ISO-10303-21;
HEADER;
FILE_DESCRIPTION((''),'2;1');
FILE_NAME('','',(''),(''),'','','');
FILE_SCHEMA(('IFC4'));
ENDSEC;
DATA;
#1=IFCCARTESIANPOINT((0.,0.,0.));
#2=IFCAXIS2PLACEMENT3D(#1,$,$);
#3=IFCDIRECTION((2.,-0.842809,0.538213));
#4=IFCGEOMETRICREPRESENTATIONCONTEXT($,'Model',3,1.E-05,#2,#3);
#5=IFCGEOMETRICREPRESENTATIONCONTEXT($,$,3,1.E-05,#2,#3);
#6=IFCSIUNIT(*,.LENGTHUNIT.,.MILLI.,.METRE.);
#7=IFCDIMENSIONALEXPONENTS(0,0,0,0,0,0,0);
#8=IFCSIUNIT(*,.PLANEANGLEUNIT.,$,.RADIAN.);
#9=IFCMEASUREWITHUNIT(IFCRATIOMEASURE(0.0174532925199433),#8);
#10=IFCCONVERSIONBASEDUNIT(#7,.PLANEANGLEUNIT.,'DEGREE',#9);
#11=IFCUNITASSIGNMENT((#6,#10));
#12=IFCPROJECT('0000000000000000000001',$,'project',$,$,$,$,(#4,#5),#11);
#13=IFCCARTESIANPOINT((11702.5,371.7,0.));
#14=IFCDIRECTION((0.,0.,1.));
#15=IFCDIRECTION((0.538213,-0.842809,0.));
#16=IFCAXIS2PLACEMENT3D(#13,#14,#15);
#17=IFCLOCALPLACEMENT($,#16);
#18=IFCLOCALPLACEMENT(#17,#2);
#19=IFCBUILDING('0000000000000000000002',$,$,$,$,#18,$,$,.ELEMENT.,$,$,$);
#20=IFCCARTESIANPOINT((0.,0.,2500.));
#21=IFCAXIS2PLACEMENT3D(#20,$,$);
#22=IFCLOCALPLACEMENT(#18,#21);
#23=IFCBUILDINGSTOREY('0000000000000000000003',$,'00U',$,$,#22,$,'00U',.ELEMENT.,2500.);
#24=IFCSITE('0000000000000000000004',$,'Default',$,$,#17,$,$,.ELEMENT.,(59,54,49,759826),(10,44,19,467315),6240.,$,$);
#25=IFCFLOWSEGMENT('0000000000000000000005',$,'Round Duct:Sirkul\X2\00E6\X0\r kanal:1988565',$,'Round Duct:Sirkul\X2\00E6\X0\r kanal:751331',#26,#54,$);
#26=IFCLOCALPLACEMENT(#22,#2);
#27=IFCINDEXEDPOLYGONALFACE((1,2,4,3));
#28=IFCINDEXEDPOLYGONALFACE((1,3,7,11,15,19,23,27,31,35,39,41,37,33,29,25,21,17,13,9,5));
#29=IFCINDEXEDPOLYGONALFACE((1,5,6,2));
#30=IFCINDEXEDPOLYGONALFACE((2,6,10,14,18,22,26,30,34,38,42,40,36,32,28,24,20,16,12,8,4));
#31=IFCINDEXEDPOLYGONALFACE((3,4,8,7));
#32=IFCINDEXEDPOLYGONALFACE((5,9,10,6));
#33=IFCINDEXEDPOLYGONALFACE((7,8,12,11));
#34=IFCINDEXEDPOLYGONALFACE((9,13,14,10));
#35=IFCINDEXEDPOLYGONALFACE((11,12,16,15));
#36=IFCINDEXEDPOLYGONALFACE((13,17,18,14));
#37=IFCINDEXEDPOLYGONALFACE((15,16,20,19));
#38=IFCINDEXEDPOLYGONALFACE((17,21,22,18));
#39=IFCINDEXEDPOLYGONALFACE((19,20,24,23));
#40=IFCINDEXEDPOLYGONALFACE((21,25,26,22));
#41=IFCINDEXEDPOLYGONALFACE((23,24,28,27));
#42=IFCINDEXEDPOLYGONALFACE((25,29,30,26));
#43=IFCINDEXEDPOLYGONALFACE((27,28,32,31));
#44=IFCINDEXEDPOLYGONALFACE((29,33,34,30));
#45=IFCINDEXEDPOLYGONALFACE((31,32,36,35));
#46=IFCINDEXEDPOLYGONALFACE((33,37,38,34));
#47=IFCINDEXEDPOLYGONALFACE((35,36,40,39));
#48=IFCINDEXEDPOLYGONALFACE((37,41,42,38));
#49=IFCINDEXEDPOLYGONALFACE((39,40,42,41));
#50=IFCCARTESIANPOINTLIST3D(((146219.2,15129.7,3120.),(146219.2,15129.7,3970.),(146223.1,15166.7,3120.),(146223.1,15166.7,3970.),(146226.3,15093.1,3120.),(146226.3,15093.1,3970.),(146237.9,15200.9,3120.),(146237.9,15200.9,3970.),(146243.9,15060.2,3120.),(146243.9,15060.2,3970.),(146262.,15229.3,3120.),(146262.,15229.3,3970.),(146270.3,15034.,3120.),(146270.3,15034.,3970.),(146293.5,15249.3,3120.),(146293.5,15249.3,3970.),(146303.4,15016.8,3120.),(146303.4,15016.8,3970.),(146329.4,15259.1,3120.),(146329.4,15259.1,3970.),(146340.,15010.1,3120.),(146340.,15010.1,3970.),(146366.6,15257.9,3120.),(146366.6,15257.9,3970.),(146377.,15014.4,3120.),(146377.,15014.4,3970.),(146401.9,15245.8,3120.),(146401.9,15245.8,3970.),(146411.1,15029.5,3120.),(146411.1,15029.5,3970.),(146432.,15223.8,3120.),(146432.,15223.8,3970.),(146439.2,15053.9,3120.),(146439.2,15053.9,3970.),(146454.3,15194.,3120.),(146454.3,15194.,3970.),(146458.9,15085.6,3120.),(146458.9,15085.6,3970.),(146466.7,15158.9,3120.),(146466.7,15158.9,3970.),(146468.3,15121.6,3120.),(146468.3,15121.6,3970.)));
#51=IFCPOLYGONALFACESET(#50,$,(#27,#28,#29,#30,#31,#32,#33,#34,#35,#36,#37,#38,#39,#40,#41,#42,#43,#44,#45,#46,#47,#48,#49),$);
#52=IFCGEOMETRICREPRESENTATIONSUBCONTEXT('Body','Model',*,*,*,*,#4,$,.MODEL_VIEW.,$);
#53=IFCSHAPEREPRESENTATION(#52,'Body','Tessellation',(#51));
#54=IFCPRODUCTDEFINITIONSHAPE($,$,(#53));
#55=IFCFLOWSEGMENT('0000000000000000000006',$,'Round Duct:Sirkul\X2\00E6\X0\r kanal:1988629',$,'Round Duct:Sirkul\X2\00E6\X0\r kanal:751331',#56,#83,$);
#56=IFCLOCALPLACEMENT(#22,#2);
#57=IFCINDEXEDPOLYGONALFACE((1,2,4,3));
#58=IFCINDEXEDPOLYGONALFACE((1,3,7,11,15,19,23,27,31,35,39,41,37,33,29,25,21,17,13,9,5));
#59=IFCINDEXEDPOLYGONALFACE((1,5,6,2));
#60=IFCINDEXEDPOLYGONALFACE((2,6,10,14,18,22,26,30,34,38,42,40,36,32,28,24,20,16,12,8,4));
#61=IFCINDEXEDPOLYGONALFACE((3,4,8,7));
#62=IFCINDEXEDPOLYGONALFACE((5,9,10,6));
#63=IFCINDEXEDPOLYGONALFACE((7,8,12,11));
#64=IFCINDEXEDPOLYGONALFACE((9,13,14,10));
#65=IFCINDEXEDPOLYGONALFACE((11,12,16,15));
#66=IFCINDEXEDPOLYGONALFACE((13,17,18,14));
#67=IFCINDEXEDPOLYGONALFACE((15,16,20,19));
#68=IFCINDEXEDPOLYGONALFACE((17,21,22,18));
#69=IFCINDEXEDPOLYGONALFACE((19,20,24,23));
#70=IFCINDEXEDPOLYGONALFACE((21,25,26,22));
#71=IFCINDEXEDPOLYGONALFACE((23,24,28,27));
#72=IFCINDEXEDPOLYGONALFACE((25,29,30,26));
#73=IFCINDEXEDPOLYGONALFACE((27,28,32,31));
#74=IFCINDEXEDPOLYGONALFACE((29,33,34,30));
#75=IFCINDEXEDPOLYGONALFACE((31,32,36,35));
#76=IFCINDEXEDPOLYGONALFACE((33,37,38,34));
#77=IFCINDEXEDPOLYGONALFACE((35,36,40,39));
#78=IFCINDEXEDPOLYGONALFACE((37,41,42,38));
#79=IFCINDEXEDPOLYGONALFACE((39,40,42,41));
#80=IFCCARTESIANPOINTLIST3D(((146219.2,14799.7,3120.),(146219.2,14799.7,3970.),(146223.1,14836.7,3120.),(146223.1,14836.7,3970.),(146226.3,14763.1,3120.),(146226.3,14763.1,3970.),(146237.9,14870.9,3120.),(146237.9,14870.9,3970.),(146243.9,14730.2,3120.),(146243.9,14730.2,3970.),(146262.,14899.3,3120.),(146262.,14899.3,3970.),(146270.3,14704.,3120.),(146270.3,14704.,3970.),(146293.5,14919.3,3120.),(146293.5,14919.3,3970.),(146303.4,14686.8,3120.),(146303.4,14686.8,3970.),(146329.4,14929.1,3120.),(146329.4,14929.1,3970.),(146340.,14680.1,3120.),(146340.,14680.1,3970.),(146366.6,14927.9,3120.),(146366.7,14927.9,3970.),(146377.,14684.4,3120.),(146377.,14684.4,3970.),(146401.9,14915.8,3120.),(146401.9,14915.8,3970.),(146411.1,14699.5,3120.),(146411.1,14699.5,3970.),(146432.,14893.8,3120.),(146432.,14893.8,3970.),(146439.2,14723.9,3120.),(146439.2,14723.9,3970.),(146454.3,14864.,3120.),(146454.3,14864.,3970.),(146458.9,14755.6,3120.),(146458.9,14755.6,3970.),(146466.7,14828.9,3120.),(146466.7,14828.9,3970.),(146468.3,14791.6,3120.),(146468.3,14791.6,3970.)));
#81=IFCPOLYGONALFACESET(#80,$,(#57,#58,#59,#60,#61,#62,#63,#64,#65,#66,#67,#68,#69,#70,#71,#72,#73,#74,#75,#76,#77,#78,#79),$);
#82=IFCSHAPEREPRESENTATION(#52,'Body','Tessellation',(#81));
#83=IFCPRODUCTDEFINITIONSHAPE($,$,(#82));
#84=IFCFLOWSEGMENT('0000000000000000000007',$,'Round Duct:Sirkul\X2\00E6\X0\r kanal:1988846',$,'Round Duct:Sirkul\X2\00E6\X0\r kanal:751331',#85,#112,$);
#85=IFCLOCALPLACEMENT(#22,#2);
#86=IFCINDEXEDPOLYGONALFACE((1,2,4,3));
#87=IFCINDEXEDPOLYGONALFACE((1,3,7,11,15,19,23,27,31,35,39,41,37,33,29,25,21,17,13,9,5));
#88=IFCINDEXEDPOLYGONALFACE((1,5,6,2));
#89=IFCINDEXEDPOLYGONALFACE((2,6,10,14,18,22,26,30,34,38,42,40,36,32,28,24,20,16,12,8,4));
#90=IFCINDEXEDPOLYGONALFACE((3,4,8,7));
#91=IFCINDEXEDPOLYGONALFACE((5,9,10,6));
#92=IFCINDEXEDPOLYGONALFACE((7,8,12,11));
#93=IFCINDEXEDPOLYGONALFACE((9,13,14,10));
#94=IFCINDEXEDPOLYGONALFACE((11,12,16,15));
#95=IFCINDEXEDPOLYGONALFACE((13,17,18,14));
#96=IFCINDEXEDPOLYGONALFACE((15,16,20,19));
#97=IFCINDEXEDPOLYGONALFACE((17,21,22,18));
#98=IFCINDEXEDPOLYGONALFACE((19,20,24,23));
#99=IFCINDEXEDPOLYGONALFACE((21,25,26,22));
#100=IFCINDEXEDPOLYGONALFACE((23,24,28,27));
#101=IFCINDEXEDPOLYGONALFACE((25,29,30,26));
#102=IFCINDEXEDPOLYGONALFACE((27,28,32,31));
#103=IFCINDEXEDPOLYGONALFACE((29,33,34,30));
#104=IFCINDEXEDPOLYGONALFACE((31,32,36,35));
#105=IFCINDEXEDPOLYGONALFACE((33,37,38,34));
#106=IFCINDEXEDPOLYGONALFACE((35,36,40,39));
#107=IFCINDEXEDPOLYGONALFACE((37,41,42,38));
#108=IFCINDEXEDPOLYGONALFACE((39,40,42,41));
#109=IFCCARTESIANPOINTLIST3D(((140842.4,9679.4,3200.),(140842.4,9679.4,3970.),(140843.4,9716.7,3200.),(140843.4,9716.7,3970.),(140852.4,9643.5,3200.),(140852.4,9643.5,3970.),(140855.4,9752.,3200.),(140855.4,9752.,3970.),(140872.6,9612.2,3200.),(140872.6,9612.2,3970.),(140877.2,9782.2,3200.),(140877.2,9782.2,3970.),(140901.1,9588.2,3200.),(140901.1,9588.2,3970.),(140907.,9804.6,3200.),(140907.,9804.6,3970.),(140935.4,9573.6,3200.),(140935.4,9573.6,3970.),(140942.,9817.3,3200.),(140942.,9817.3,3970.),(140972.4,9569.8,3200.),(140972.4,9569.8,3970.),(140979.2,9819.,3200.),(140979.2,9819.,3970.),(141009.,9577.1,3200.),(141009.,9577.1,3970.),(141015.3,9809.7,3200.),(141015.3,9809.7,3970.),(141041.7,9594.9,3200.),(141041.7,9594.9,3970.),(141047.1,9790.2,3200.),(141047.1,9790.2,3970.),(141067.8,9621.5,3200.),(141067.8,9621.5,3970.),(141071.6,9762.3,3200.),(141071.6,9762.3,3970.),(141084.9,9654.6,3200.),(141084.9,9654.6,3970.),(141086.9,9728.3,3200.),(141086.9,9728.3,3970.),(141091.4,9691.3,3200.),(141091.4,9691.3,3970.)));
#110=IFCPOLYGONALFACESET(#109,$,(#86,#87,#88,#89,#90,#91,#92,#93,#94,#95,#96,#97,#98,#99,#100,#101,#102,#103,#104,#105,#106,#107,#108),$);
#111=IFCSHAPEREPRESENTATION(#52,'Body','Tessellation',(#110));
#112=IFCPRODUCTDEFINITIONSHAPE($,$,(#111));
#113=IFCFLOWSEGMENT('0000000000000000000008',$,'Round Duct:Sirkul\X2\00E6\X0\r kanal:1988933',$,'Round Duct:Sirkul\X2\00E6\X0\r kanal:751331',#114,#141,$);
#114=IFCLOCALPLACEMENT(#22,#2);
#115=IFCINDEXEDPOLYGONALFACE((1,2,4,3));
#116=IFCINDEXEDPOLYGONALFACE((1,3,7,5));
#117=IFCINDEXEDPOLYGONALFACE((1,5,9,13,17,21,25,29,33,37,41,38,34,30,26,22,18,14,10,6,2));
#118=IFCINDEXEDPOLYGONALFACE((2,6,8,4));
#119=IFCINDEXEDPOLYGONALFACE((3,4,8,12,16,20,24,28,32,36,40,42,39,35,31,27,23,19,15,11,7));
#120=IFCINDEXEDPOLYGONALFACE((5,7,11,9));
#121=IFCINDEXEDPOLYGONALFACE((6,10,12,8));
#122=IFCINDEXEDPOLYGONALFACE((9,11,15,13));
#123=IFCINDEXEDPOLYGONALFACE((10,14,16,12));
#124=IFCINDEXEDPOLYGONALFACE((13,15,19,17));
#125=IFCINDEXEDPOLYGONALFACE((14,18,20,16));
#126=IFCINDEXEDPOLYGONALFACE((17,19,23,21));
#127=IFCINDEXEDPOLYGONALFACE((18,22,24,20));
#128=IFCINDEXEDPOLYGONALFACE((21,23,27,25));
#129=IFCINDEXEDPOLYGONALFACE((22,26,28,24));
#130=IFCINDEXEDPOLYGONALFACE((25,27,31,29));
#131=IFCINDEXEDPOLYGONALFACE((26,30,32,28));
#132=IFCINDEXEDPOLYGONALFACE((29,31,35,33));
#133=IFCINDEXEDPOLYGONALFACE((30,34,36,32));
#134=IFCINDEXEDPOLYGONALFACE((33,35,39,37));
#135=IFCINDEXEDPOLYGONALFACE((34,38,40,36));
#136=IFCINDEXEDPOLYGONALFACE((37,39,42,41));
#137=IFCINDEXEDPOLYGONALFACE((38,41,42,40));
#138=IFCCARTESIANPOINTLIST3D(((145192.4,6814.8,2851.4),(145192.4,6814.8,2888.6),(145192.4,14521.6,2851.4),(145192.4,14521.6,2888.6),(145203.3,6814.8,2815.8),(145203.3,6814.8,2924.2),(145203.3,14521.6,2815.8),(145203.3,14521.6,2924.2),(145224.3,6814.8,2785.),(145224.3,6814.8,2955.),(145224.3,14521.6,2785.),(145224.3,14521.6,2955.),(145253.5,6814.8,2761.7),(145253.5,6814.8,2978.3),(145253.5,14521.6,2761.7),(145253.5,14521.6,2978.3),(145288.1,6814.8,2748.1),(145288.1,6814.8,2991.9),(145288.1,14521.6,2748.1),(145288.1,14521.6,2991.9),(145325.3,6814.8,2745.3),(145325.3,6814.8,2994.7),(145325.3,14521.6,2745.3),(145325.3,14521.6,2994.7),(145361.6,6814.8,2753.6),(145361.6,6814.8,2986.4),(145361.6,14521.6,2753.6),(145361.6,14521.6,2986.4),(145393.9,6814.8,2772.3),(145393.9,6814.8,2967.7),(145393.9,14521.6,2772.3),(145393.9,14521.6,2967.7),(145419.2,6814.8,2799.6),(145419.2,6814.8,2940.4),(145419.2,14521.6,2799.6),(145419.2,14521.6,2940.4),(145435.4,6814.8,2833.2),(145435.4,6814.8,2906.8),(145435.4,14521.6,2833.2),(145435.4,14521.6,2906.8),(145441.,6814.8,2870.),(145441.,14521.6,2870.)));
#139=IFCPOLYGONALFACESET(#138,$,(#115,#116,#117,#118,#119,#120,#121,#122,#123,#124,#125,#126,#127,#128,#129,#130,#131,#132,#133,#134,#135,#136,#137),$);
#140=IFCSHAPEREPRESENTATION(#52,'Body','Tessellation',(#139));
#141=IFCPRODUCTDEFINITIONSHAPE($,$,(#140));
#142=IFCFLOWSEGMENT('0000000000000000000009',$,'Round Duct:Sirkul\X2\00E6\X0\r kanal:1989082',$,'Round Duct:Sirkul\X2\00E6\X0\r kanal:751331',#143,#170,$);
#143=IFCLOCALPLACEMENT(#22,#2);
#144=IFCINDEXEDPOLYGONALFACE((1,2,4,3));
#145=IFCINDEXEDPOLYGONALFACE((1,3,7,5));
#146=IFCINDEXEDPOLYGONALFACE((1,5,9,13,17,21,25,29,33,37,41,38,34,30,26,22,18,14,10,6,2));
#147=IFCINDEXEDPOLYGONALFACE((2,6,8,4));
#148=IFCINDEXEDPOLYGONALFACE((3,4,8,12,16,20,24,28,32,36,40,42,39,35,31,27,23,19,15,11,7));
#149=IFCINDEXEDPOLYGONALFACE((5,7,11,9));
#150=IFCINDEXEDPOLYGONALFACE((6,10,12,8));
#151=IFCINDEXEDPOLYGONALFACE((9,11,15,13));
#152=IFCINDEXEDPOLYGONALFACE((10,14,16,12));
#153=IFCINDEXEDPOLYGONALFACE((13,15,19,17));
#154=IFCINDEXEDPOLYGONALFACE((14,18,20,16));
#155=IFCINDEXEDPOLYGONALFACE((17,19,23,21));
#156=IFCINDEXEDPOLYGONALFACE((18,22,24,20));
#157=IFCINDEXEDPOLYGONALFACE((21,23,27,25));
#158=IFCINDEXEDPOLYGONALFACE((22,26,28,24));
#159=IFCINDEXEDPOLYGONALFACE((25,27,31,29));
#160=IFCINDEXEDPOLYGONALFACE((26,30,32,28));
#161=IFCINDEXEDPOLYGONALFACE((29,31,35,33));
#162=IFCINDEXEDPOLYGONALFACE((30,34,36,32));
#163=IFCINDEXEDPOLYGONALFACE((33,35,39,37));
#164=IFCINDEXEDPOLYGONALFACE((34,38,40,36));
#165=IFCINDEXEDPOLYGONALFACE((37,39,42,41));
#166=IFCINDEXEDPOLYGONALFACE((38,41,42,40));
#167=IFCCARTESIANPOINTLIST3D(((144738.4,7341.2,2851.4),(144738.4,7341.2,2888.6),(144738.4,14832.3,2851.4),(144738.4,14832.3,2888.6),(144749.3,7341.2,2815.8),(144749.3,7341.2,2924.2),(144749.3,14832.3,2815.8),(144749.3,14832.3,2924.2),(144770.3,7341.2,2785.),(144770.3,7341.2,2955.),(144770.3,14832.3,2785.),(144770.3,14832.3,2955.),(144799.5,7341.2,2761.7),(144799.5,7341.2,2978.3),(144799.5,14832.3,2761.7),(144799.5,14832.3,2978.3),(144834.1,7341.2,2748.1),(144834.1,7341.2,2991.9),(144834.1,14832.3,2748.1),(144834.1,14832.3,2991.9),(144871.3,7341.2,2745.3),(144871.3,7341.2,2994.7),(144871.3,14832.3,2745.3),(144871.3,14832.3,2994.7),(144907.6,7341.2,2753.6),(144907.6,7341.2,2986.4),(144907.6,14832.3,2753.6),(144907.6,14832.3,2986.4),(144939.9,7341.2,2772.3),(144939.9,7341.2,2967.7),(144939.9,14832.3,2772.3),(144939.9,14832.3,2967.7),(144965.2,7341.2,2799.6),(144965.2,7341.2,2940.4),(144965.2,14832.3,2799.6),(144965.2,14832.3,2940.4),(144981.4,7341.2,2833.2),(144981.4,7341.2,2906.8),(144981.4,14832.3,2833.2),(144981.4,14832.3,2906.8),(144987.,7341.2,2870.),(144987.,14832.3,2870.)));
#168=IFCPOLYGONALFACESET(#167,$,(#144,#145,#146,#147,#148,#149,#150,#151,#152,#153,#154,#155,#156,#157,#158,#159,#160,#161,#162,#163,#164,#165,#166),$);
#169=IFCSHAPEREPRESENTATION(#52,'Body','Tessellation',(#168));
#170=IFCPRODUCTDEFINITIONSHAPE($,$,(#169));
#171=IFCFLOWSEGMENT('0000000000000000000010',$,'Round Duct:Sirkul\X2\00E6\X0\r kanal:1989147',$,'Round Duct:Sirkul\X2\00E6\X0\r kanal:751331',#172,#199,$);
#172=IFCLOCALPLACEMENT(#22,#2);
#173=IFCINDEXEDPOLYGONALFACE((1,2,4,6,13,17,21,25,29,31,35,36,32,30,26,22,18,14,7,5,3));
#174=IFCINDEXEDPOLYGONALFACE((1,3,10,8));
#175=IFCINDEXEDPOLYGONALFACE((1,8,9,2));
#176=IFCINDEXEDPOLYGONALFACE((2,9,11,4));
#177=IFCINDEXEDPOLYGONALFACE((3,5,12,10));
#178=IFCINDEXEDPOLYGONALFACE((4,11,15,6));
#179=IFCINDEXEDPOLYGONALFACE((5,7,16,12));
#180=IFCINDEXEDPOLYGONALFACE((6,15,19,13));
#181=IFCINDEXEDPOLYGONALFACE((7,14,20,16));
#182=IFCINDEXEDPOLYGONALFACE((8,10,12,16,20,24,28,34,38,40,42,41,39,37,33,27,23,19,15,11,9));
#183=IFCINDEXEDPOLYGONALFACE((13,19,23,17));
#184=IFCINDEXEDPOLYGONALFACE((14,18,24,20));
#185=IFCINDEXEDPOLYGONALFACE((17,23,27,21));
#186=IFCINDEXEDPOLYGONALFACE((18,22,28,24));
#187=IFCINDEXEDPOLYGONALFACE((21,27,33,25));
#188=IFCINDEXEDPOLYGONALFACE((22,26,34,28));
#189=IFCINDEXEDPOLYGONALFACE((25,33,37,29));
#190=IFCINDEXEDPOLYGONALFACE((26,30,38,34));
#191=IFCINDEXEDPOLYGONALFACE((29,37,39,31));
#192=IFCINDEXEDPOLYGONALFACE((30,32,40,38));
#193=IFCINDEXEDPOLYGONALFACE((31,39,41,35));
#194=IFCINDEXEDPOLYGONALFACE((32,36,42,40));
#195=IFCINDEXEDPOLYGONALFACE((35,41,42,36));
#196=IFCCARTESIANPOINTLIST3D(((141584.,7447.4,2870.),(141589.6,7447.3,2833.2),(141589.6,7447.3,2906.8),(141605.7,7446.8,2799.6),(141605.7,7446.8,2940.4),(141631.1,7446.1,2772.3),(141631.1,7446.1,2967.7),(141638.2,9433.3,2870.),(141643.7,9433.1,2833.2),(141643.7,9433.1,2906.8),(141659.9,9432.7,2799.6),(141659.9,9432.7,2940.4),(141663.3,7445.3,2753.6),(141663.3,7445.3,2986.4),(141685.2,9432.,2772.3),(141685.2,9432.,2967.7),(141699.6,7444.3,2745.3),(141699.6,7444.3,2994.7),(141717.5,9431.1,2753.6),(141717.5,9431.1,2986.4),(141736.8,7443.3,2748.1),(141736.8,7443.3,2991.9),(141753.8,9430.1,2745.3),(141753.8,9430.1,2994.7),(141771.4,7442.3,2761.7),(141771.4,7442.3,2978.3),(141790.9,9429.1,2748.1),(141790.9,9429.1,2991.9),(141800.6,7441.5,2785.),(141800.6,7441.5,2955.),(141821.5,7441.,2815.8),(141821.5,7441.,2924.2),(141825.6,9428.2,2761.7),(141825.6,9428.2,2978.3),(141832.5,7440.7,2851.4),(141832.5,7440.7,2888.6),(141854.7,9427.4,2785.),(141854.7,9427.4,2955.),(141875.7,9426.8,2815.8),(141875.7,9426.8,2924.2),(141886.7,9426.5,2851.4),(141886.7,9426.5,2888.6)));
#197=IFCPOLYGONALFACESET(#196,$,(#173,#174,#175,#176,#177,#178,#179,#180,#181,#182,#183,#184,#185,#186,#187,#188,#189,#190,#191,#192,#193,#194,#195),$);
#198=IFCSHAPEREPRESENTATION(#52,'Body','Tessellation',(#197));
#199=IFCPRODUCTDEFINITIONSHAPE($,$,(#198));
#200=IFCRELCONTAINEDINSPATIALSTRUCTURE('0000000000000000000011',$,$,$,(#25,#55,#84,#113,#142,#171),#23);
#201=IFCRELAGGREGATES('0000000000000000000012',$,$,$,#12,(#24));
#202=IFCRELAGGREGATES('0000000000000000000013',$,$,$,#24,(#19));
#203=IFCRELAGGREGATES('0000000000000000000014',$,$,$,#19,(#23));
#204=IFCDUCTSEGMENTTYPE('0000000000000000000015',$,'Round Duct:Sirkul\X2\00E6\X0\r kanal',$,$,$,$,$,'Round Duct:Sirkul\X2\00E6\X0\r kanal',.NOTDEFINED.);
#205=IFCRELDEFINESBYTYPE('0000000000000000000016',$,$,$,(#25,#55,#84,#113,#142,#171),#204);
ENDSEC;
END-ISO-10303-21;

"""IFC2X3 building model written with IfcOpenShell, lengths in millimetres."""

from ifc_helpers import new_model, entity, si_unit, converted_unit, direction, frame, frame_2d, origin, origin_2d_with_axis, place, context, subcontext, project, spatial, circle, extrude, type_object, element, save


model = new_model("IFC2X3")

# Units and contexts
model_context = context("Model", 3, precision=1e-05, world=origin(), true_north=direction((2.0, -0.842809, 0.538213)))
context_of_model = context(None, 3, precision=1e-05, world=origin(), true_north=direction((2.0, -0.842809, 0.538213)))
body_context = subcontext(model_context, "Body", "Model", "MODEL_VIEW")
ifc_project = project(units=[si_unit("LENGTHUNIT", "METRE", prefix="MILLI"), converted_unit("PLANEANGLEUNIT", "DEGREE", entity("IfcRatioMeasure", 0.0174532925199433), si_unit("PLANEANGLEUNIT", "RADIAN"), dimensions=[0, 0, 0, 0, 0, 0, 0])], contexts=[model_context, context_of_model])

# Site, building, storey
site_placement = place(None, frame((11702.5, 371.7, 0.0), z_axis=(0.0, 0.0, 1.0), x_axis=(0.538213, -0.842809, 0.0)))
site = spatial("IfcSite", under=ifc_project, at=site_placement, Name="Default", CompositionType="ELEMENT", RefLatitude=(59, 54, 49, 759826), RefLongitude=(10, 44, 19, 467315), RefElevation=6240.0)
building_placement = place(site_placement, origin())
building = spatial("IfcBuilding", under=site, at=building_placement, CompositionType="ELEMENT")
storey_placement = place(building_placement, frame((0.0, 0.0, 2500.0)))
storey = spatial("IfcBuildingStorey", under=building, at=storey_placement, Name="00U", LongName="00U", CompositionType="ELEMENT", Elevation=2500.0)

# Flow segments
duct_segment_type_1 = type_object("IfcDuctSegmentType", Name="Round Duct:Sirkulær kanal", ElementType="Round Duct:Sirkulær kanal", PredefinedType="NOTDEFINED")
flow_segment_1_placement = place(storey_placement, origin())
element("IfcFlowSegment", 1, at=flow_segment_1_placement, inside=storey, type_object=duct_segment_type_1, Name="Round Duct:Sirkulær kanal:1988565", ObjectType="Round Duct:Sirkulær kanal:751331", context=body_context, shape_type="SweptSolid", body=[
    extrude(circle(Radius=125.0, at=frame_2d((0.0, 0.0), x_axis=(1.0, 0.0))), frame((146344.0, 15135.0, 3120.0), z_axis=(0.000001, 0.0, 1.0), x_axis=(-0.999095, -0.042537, 0.000001)), (0.0, 0.0, 1.0), 850.0),
])
flow_segment_2_placement = place(storey_placement, origin())
element("IfcFlowSegment", 2, at=flow_segment_2_placement, inside=storey, type_object=duct_segment_type_1, Name="Round Duct:Sirkulær kanal:1988629", ObjectType="Round Duct:Sirkulær kanal:751331", context=body_context, shape_type="SweptSolid", body=[
    extrude(circle(Radius=125.0, at=frame_2d((0.0, 0.0), x_axis=(1.0, 0.0))), frame((146344.0, 14805.0, 3120.0), z_axis=(0.000001, 0.0, 1.0), x_axis=(-0.999095, -0.042537, 0.000001)), (0.0, 0.0, 1.0), 850.0),
])
flow_segment_3_placement = place(storey_placement, origin())
element("IfcFlowSegment", 3, at=flow_segment_3_placement, inside=storey, type_object=duct_segment_type_1, Name="Round Duct:Sirkulær kanal:1988846", ObjectType="Round Duct:Sirkulær kanal:751331", context=body_context, shape_type="SweptSolid", body=[
    extrude(circle(Radius=125.0, at=frame_2d((0.0, 0.0), x_axis=(1.0, 0.0))), frame((140966.5, 9694.7, 3200.0), z_axis=(0.000001, 0.0, 1.0), x_axis=(0.999628, -0.02726, -0.000001)), (0.0, 0.0, 1.0), 770.0),
])
flow_segment_4_placement = place(storey_placement, origin())
element("IfcFlowSegment", 4, at=flow_segment_4_placement, inside=storey, type_object=duct_segment_type_1, Name="Round Duct:Sirkulær kanal:1988933", ObjectType="Round Duct:Sirkulær kanal:751331", context=body_context, shape_type="SweptSolid", body=[
    extrude(circle(Radius=125.0, at=frame_2d((0.0, 0.0), x_axis=(1.0, 0.0))), frame((145316.0, 6814.8, 2870.0), z_axis=(0.0, 1.0, 0.0), x_axis=(1.0, 0.0, 0.0)), (0.0, 0.0, 1.0), 7706.8),
])
flow_segment_5_placement = place(storey_placement, origin())
element("IfcFlowSegment", 5, at=flow_segment_5_placement, inside=storey, type_object=duct_segment_type_1, Name="Round Duct:Sirkulær kanal:1989082", ObjectType="Round Duct:Sirkulær kanal:751331", context=body_context, shape_type="SweptSolid", body=[
    extrude(circle(Radius=125.0, at=frame_2d((0.0, 0.0), x_axis=(1.0, 0.0))), frame((144862.0, 7341.2, 2870.0), z_axis=(0.0, 1.0, 0.0), x_axis=(1.0, 0.0, 0.0)), (0.0, 0.0, 1.0), 7491.1),
])
flow_segment_6_placement = place(storey_placement, origin())
element("IfcFlowSegment", 6, at=flow_segment_6_placement, inside=storey, type_object=duct_segment_type_1, Name="Round Duct:Sirkulær kanal:1989147", ObjectType="Round Duct:Sirkulær kanal:751331", context=body_context, shape_type="SweptSolid", body=[
    extrude(circle(Radius=125.0, at=origin_2d_with_axis()), frame((141709.0, 7444.0, 2870.0), z_axis=(0.02726, 0.999628, 0.0), x_axis=(-0.999628, 0.02726, 0.0)), (0.0, 0.0, 1.0), 1986.6),
])

save(model, "model.ifc")
